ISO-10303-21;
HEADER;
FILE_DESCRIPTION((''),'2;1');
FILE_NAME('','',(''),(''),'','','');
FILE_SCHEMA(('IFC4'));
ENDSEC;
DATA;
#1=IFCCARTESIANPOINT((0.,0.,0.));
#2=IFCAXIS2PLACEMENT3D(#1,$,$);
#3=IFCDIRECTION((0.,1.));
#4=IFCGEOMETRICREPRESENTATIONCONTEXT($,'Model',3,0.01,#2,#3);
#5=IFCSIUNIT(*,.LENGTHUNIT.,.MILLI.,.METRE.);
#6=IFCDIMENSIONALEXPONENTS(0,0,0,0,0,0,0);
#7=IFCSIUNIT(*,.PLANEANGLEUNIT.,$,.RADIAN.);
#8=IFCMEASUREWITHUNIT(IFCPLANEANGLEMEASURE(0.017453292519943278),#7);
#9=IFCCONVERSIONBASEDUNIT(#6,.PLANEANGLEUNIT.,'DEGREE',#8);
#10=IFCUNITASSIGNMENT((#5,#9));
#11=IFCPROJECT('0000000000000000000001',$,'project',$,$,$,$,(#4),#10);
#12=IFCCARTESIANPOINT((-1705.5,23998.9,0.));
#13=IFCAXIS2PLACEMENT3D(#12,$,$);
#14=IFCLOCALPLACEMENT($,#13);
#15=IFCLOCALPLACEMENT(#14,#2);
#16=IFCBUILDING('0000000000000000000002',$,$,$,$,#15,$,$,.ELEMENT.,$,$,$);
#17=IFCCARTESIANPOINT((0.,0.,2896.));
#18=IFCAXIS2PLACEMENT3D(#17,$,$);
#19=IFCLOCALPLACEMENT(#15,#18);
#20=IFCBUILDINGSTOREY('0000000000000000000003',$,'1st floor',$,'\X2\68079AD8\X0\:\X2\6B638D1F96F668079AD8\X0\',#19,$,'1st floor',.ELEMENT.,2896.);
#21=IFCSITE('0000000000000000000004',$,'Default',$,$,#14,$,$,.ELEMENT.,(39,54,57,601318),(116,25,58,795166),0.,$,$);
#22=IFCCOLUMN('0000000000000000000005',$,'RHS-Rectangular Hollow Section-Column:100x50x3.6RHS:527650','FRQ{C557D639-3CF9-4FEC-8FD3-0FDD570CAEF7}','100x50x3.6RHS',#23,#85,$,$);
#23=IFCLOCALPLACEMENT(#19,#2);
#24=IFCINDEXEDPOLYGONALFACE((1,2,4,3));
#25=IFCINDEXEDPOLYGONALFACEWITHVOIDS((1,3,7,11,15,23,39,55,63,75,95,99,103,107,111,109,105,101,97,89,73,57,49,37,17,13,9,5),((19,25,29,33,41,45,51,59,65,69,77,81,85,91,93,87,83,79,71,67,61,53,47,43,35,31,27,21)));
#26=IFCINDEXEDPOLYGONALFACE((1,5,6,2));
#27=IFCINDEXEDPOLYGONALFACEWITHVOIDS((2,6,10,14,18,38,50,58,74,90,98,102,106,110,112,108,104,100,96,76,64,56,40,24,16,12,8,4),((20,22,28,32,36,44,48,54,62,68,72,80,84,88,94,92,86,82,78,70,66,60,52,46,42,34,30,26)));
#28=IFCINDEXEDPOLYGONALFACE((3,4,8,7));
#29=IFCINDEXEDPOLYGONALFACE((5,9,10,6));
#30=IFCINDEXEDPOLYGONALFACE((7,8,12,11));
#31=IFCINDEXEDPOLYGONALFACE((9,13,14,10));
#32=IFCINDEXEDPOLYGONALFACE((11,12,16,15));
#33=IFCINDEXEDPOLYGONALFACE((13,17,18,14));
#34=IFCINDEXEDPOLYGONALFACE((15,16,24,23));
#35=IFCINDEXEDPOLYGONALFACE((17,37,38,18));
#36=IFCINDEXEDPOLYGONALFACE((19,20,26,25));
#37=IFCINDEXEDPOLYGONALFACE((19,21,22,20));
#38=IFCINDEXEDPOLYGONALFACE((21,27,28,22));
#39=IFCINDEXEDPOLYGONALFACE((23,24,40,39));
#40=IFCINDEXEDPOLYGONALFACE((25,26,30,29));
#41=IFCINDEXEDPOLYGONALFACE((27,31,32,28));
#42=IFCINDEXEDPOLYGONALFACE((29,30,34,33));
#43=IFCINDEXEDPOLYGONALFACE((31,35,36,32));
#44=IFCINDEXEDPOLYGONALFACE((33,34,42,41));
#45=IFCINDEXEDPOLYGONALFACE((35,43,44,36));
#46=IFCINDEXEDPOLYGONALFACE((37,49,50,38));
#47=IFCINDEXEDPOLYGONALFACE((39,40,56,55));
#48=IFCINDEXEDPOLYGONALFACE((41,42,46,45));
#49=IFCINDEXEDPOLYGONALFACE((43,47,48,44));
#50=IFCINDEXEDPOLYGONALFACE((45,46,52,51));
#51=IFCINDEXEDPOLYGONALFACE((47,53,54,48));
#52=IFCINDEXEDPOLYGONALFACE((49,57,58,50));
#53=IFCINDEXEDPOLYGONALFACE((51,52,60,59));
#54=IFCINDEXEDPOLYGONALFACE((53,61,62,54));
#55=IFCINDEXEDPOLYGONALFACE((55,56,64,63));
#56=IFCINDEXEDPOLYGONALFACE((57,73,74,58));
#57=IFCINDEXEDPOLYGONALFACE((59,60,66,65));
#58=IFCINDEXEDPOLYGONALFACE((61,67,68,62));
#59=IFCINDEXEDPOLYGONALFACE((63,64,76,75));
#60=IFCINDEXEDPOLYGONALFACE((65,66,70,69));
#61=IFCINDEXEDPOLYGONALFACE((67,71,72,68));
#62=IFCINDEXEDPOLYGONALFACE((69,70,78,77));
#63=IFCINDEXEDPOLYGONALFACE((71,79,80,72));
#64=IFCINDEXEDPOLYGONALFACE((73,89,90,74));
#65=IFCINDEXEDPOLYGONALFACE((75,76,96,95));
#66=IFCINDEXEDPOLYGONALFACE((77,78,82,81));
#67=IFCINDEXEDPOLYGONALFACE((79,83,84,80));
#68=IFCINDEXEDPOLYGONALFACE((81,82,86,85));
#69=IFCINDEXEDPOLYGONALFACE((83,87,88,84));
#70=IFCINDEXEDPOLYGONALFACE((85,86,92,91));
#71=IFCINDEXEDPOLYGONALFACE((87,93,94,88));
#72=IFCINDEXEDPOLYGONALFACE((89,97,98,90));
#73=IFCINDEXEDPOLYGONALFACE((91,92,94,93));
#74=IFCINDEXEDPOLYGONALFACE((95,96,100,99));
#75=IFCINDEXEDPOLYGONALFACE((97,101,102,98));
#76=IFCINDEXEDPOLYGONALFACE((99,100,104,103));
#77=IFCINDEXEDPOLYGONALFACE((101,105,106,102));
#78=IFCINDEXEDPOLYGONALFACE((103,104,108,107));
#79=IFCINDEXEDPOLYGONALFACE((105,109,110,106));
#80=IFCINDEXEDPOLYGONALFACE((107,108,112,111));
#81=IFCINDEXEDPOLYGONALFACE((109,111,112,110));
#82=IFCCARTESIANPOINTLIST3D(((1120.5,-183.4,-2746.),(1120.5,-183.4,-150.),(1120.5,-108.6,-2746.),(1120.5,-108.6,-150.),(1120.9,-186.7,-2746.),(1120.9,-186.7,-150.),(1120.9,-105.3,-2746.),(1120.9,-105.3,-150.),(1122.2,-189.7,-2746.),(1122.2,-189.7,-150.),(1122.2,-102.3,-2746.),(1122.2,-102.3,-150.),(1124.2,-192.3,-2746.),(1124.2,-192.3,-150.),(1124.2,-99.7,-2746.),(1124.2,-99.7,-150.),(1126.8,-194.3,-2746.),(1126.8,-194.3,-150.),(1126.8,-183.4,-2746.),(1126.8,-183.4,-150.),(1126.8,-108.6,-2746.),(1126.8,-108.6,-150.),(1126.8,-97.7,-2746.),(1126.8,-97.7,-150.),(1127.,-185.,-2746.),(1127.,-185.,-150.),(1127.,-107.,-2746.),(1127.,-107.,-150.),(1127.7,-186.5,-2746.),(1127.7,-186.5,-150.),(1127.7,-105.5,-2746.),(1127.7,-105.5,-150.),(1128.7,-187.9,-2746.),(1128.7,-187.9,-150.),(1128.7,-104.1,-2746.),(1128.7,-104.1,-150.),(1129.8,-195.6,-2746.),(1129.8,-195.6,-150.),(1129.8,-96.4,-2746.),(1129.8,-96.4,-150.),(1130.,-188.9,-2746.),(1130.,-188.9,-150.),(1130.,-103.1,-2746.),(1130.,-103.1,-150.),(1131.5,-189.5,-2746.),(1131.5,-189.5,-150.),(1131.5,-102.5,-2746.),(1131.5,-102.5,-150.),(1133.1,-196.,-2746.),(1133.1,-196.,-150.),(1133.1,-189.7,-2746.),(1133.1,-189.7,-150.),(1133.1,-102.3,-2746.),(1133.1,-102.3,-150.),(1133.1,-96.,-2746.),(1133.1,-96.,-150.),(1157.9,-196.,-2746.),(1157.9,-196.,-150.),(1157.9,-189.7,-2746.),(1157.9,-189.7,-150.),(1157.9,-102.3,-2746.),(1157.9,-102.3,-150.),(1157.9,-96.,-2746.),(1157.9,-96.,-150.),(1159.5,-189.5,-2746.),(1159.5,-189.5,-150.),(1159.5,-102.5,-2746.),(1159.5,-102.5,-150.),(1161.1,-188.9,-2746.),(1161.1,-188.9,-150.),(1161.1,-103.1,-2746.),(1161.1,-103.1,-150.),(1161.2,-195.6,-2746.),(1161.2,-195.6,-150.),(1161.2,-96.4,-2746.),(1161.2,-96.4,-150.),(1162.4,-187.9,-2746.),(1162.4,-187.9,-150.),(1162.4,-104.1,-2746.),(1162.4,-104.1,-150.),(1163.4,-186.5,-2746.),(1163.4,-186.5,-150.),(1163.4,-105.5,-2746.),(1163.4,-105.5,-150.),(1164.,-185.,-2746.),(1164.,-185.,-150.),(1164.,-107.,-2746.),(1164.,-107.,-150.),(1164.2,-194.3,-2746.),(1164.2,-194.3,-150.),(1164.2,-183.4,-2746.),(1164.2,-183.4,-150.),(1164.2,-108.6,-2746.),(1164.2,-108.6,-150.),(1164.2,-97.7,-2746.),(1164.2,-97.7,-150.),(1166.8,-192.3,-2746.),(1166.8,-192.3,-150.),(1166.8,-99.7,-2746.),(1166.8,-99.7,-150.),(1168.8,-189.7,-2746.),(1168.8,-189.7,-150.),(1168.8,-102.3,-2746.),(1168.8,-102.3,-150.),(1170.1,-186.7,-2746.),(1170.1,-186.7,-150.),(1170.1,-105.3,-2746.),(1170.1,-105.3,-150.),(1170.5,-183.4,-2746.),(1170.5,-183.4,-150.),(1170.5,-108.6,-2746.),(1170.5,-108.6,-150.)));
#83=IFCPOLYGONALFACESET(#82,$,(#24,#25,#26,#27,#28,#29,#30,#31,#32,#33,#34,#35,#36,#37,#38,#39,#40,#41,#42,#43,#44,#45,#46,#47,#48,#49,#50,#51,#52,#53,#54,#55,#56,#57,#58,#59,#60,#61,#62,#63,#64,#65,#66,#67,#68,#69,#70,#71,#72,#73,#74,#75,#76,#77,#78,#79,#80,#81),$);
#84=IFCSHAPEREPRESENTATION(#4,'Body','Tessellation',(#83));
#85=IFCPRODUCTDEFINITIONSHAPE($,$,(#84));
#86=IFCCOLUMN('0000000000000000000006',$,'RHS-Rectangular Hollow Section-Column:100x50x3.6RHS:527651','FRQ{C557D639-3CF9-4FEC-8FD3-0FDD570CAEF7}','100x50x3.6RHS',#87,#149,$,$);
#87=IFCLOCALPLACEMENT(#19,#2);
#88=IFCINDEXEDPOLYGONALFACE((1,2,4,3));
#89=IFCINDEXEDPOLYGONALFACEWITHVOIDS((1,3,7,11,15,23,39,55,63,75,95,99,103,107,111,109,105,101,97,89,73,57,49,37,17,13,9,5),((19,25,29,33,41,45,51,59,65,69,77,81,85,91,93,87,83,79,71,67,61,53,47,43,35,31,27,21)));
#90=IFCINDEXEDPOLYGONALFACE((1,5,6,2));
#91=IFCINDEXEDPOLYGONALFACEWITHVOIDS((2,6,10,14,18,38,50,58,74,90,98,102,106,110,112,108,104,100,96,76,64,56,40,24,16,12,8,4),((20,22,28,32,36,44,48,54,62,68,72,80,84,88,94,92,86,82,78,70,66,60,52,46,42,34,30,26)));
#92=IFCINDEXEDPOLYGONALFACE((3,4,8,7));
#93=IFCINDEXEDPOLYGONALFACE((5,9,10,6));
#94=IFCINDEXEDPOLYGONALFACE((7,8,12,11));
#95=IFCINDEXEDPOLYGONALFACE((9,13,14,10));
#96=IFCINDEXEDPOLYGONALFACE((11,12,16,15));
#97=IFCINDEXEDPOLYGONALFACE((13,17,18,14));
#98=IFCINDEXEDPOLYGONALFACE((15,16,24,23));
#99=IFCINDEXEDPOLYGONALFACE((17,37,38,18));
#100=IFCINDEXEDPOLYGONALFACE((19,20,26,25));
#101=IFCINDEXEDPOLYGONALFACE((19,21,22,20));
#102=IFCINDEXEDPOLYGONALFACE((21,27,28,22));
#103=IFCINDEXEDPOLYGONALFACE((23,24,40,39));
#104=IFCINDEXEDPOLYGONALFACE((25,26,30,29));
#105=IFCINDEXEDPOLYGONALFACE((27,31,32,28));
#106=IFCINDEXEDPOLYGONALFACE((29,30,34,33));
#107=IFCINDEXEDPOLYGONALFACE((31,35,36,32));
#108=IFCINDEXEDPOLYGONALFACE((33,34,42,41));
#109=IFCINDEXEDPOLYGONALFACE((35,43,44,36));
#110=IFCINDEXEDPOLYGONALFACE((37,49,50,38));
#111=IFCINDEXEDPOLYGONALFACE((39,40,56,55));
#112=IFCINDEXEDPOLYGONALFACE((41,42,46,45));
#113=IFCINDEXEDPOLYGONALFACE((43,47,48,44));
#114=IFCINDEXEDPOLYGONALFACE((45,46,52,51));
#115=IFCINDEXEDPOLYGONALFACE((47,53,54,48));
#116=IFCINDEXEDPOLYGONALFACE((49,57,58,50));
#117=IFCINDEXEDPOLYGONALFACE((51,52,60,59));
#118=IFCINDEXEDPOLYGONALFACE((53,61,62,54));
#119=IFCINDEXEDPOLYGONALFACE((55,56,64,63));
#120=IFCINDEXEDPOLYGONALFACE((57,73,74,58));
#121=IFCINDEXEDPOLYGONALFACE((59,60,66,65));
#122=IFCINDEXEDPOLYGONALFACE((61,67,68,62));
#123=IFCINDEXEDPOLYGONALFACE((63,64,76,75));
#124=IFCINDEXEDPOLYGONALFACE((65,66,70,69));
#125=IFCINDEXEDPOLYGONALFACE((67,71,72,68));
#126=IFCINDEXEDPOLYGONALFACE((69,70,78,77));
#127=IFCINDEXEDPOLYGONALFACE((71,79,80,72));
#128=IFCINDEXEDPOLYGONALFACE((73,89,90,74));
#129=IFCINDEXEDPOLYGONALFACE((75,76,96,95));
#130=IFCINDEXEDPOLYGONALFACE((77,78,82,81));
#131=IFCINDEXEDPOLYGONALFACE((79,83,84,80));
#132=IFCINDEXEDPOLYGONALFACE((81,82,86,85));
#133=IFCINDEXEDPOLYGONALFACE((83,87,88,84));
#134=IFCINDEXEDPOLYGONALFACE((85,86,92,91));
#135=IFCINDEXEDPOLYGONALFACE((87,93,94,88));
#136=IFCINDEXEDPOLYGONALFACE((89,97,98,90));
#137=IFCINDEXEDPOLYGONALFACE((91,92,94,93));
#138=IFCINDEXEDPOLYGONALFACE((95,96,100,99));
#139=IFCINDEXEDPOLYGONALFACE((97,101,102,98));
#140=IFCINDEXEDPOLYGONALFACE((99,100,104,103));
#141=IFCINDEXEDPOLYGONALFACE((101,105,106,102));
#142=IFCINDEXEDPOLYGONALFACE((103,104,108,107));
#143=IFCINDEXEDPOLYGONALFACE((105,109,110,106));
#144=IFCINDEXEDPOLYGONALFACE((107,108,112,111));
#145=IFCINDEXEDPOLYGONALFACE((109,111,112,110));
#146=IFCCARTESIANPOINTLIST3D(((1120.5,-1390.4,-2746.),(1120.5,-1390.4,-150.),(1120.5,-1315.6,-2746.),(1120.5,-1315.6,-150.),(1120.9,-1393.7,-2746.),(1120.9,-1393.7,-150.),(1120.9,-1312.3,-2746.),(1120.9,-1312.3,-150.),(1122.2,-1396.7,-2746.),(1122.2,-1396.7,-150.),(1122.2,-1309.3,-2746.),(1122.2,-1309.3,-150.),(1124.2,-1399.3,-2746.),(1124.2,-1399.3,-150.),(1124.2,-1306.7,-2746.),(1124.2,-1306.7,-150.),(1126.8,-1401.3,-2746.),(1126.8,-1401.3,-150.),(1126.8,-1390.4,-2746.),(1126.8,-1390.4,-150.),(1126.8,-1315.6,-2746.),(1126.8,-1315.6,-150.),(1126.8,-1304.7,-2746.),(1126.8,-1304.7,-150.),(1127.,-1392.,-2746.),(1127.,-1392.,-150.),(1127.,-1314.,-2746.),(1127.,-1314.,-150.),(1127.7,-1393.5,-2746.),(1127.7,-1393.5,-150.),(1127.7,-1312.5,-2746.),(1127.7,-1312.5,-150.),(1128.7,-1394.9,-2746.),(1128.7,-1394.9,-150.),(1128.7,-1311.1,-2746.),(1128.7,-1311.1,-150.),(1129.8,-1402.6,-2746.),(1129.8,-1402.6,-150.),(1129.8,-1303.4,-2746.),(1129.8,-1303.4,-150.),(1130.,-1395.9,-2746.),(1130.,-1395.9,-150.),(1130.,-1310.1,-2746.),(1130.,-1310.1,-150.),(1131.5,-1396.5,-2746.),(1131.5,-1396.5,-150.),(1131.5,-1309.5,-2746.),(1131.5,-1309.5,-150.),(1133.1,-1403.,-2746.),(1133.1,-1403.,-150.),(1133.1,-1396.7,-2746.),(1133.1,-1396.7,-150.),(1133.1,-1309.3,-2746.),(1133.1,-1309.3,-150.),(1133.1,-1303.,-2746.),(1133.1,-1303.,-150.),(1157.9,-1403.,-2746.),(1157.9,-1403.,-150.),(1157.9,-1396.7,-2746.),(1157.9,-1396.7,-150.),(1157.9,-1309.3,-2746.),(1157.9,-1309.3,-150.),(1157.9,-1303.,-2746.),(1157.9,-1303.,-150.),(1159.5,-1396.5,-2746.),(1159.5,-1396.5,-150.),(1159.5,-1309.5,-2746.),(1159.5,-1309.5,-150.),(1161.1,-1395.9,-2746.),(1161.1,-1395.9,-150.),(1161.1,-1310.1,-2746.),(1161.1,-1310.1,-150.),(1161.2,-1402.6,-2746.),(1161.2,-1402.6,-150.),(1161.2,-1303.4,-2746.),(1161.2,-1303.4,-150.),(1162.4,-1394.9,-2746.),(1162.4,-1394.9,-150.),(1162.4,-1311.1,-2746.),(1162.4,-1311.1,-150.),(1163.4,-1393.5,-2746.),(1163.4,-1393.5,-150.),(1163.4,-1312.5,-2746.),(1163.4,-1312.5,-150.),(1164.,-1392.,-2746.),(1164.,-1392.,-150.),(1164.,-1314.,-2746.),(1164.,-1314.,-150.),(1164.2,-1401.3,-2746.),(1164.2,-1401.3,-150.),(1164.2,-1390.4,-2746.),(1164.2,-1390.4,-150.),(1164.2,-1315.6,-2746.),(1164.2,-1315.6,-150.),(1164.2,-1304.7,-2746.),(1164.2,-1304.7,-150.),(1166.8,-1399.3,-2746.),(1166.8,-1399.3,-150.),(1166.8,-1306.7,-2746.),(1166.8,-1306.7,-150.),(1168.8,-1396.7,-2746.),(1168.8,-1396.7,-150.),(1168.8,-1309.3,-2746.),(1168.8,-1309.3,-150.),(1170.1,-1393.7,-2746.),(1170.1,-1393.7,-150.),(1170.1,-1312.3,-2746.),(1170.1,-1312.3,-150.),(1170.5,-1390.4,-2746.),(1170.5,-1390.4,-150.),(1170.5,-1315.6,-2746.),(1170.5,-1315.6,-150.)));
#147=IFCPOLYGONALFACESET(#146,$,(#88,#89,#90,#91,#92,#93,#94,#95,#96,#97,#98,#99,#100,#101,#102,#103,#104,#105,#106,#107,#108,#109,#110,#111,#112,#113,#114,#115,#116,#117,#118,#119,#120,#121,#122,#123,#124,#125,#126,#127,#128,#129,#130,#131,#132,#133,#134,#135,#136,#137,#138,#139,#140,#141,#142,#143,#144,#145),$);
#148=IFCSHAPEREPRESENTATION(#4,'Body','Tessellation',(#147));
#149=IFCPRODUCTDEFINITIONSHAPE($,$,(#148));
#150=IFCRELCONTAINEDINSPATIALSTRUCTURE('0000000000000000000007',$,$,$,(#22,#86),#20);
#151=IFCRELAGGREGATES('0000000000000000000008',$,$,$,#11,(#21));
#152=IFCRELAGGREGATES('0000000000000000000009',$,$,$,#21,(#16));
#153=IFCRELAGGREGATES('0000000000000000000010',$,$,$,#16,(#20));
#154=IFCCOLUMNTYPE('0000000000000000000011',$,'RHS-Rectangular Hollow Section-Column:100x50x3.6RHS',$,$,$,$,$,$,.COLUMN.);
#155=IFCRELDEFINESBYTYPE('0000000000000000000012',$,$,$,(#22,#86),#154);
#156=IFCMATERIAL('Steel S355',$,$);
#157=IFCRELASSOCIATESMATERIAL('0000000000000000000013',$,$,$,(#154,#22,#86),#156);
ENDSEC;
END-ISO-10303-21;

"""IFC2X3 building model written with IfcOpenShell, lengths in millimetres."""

from ifc_helpers import new_model, entity, si_unit, converted_unit, point, direction, frame, frame_2d, origin, origin_2d, place, context, project, spatial, circle_curve, line_curve, trimmed, segment, composite_curve, hollow_rectangle, outline, extrude, clip, halfspace, material, type_object, element, save


model = new_model("IFC2X3")

# Units and contexts
model_context = context("Model", 3, precision=0.01, world=origin(), true_north=direction((0.0, 1.0)))
ifc_project = project(units=[si_unit("LENGTHUNIT", "METRE", prefix="MILLI"), converted_unit("PLANEANGLEUNIT", "DEGREE", entity("IfcPlaneAngleMeasure", 0.017453292519943278), si_unit("PLANEANGLEUNIT", "RADIAN"), dimensions=[0, 0, 0, 0, 0, 0, 0])], contexts=[model_context])

# Site, building, storey
site_placement = place(None, frame((-1705.5, 23998.9, 0.0)))
site = spatial("IfcSite", under=ifc_project, at=site_placement, Name="Default", CompositionType="ELEMENT", RefLatitude=(39, 54, 57, 601318), RefLongitude=(116, 25, 58, 795166), RefElevation=0.0)
building_placement = place(site_placement, origin())
building = spatial("IfcBuilding", under=site, at=building_placement, CompositionType="ELEMENT")
storey_placement = place(building_placement, frame((0.0, 0.0, 2896.0)))
storey = spatial("IfcBuildingStorey", under=building, at=storey_placement, Name="1st floor", ObjectType="标高:正负零标高", LongName="1st floor", CompositionType="ELEMENT", Elevation=2896.0)

# Shared definitions
ifc_material_1 = material(Name="Steel S355")

# Columns, openings
column_type_1 = type_object("IfcColumnType", Name="RHS-Rectangular Hollow Section-Column:100x50x3.6RHS", PredefinedType="COLUMN", material=ifc_material_1)
column_1_placement = place(storey_placement, frame((1145.5, -146.0, -19.1)))
column_1 = element("IfcColumn", 1, at=column_1_placement, inside=storey, type_object=column_type_1, material=ifc_material_1, Name="RHS-Rectangular Hollow Section-Column:100x50x3.6RHS:527650", Description="FRQ{C557D639-3CF9-4FEC-8FD3-0FDD570CAEF7}", ObjectType="100x50x3.6RHS", context=model_context, shape_type="Clipping", body=[
    clip(clip(extrude(hollow_rectangle(XDim=50.0, YDim=100.0, WallThickness=6.3, InnerFilletRadius=6.3, OuterFilletRadius=12.6, at=origin_2d()), origin(), (0.0, 0.0, -1.0), 2782.8), halfspace(frame((-1145.5, 146.0, -55.9), z_axis=(0.0, 0.0, -1.0), x_axis=(-1.0, 0.0, 0.0)), True)), halfspace(frame((-1145.5, 146.0, -2726.9), z_axis=(0.0, 0.0, 1.0), x_axis=(1.0, 0.0, 0.0)), True)),
])
opening_1_placement = place(column_1_placement, frame((0.0, -150.1, -130.9), z_axis=(0.0, 1.0, 0.0), x_axis=(-1.0, 0.0, 0.0)))
element("IfcOpeningElement", 2, at=opening_1_placement, cuts=column_1, ObjectType="Opening", context=model_context, shape_type="SweptSolid", body=[
    extrude(outline(composite_curve([segment(trimmed(circle_curve(frame_2d((43.0, 32.0), x_axis=(1.0, 0.0)), 32.0), [point((43.0, 0.0))], [point((75.0, 32.0))], True, "CARTESIAN"), True, "CONTINUOUS"), segment(trimmed(line_curve((75.0, 32.0), (0.0, 1.0), 86.0), [point((75.0, 32.0))], [point((75.0, 118.0))], True, "CARTESIAN"), True, "CONTINUOUS"), segment(trimmed(circle_curve(frame_2d((43.0, 118.0), x_axis=(1.0, 0.0)), 32.0), [point((75.0, 118.0))], [point((43.0, 150.0))], True, "CARTESIAN"), True, "CONTINUOUS"), segment(trimmed(line_curve((43.0, 150.0), (-1.0, 0.0), 86.0), [point((43.0, 150.0))], [point((-43.0, 150.0))], True, "CARTESIAN"), True, "CONTINUOUS"), segment(trimmed(circle_curve(frame_2d((-43.0, 118.0), x_axis=(1.0, 0.0)), 32.0), [point((-43.0, 150.0))], [point((-75.0, 118.0))], True, "CARTESIAN"), True, "CONTINUOUS"), segment(trimmed(line_curve((-75.0, 118.0), (0.0, -1.0), 86.0), [point((-75.0, 118.0))], [point((-75.0, 32.0))], True, "CARTESIAN"), True, "CONTINUOUS"), segment(trimmed(circle_curve(frame_2d((-43.0, 32.0), x_axis=(1.0, 0.0)), 32.0), [point((-75.0, 32.0))], [point((-43.0, 0.0))], True, "CARTESIAN"), True, "CONTINUOUS"), segment(trimmed(line_curve((-43.0, 0.0), (1.0, 0.0), 86.0), [point((-43.0, 0.0))], [point((43.0, 0.0))], True, "CARTESIAN"), True, "CONTINUOUS")], self_intersect="UNKNOWN")), origin(), (0.0, 0.0, 1.0), 300.2),
])
column_2_placement = place(storey_placement, frame((1145.5, -1353.0, -19.1)))
column_2 = element("IfcColumn", 3, at=column_2_placement, inside=storey, type_object=column_type_1, material=ifc_material_1, Name="RHS-Rectangular Hollow Section-Column:100x50x3.6RHS:527651", Description="FRQ{C557D639-3CF9-4FEC-8FD3-0FDD570CAEF7}", ObjectType="100x50x3.6RHS", context=model_context, shape_type="Clipping", body=[
    clip(clip(extrude(hollow_rectangle(XDim=50.0, YDim=100.0, WallThickness=6.3, InnerFilletRadius=6.3, OuterFilletRadius=12.6, at=origin_2d()), origin(), (0.0, 0.0, -1.0), 2782.8), halfspace(frame((-1145.5, 1353.0, -2726.9), z_axis=(0.0, 0.0, 1.0), x_axis=(1.0, 0.0, 0.0)), True)), halfspace(frame((-1145.5, 1353.0, -55.9), z_axis=(0.0, 0.0, -1.0), x_axis=(-1.0, 0.0, 0.0)), True)),
])
opening_2_placement = place(column_2_placement, frame((0.0, -150.1, -130.9), z_axis=(0.0, 1.0, 0.0), x_axis=(-1.0, 0.0, 0.0)))
element("IfcOpeningElement", 4, at=opening_2_placement, cuts=column_2, ObjectType="Opening", context=model_context, shape_type="SweptSolid", body=[
    extrude(outline(composite_curve([segment(trimmed(circle_curve(frame_2d((43.0, 32.0), x_axis=(1.0, 0.0)), 32.0), [point((43.0, 0.0))], [point((75.0, 32.0))], True, "CARTESIAN"), True, "CONTINUOUS"), segment(trimmed(line_curve((75.0, 32.0), (0.0, 1.0), 86.0), [point((75.0, 32.0))], [point((75.0, 118.0))], True, "CARTESIAN"), True, "CONTINUOUS"), segment(trimmed(circle_curve(frame_2d((43.0, 118.0), x_axis=(1.0, 0.0)), 32.0), [point((75.0, 118.0))], [point((43.0, 150.0))], True, "CARTESIAN"), True, "CONTINUOUS"), segment(trimmed(line_curve((43.0, 150.0), (-1.0, 0.0), 86.0), [point((43.0, 150.0))], [point((-43.0, 150.0))], True, "CARTESIAN"), True, "CONTINUOUS"), segment(trimmed(circle_curve(frame_2d((-43.0, 118.0), x_axis=(1.0, 0.0)), 32.0), [point((-43.0, 150.0))], [point((-75.0, 118.0))], True, "CARTESIAN"), True, "CONTINUOUS"), segment(trimmed(line_curve((-75.0, 118.0), (0.0, -1.0), 86.0), [point((-75.0, 118.0))], [point((-75.0, 32.0))], True, "CARTESIAN"), True, "CONTINUOUS"), segment(trimmed(circle_curve(frame_2d((-43.0, 32.0), x_axis=(1.0, 0.0)), 32.0), [point((-75.0, 32.0))], [point((-43.0, 0.0))], True, "CARTESIAN"), True, "CONTINUOUS"), segment(trimmed(line_curve((-43.0, 0.0), (1.0, 0.0), 86.0), [point((-43.0, 0.0))], [point((43.0, 0.0))], True, "CARTESIAN"), True, "CONTINUOUS")], self_intersect="UNKNOWN")), origin(), (0.0, 0.0, 1.0), 300.2),
])

save(model, "model.ifc")
